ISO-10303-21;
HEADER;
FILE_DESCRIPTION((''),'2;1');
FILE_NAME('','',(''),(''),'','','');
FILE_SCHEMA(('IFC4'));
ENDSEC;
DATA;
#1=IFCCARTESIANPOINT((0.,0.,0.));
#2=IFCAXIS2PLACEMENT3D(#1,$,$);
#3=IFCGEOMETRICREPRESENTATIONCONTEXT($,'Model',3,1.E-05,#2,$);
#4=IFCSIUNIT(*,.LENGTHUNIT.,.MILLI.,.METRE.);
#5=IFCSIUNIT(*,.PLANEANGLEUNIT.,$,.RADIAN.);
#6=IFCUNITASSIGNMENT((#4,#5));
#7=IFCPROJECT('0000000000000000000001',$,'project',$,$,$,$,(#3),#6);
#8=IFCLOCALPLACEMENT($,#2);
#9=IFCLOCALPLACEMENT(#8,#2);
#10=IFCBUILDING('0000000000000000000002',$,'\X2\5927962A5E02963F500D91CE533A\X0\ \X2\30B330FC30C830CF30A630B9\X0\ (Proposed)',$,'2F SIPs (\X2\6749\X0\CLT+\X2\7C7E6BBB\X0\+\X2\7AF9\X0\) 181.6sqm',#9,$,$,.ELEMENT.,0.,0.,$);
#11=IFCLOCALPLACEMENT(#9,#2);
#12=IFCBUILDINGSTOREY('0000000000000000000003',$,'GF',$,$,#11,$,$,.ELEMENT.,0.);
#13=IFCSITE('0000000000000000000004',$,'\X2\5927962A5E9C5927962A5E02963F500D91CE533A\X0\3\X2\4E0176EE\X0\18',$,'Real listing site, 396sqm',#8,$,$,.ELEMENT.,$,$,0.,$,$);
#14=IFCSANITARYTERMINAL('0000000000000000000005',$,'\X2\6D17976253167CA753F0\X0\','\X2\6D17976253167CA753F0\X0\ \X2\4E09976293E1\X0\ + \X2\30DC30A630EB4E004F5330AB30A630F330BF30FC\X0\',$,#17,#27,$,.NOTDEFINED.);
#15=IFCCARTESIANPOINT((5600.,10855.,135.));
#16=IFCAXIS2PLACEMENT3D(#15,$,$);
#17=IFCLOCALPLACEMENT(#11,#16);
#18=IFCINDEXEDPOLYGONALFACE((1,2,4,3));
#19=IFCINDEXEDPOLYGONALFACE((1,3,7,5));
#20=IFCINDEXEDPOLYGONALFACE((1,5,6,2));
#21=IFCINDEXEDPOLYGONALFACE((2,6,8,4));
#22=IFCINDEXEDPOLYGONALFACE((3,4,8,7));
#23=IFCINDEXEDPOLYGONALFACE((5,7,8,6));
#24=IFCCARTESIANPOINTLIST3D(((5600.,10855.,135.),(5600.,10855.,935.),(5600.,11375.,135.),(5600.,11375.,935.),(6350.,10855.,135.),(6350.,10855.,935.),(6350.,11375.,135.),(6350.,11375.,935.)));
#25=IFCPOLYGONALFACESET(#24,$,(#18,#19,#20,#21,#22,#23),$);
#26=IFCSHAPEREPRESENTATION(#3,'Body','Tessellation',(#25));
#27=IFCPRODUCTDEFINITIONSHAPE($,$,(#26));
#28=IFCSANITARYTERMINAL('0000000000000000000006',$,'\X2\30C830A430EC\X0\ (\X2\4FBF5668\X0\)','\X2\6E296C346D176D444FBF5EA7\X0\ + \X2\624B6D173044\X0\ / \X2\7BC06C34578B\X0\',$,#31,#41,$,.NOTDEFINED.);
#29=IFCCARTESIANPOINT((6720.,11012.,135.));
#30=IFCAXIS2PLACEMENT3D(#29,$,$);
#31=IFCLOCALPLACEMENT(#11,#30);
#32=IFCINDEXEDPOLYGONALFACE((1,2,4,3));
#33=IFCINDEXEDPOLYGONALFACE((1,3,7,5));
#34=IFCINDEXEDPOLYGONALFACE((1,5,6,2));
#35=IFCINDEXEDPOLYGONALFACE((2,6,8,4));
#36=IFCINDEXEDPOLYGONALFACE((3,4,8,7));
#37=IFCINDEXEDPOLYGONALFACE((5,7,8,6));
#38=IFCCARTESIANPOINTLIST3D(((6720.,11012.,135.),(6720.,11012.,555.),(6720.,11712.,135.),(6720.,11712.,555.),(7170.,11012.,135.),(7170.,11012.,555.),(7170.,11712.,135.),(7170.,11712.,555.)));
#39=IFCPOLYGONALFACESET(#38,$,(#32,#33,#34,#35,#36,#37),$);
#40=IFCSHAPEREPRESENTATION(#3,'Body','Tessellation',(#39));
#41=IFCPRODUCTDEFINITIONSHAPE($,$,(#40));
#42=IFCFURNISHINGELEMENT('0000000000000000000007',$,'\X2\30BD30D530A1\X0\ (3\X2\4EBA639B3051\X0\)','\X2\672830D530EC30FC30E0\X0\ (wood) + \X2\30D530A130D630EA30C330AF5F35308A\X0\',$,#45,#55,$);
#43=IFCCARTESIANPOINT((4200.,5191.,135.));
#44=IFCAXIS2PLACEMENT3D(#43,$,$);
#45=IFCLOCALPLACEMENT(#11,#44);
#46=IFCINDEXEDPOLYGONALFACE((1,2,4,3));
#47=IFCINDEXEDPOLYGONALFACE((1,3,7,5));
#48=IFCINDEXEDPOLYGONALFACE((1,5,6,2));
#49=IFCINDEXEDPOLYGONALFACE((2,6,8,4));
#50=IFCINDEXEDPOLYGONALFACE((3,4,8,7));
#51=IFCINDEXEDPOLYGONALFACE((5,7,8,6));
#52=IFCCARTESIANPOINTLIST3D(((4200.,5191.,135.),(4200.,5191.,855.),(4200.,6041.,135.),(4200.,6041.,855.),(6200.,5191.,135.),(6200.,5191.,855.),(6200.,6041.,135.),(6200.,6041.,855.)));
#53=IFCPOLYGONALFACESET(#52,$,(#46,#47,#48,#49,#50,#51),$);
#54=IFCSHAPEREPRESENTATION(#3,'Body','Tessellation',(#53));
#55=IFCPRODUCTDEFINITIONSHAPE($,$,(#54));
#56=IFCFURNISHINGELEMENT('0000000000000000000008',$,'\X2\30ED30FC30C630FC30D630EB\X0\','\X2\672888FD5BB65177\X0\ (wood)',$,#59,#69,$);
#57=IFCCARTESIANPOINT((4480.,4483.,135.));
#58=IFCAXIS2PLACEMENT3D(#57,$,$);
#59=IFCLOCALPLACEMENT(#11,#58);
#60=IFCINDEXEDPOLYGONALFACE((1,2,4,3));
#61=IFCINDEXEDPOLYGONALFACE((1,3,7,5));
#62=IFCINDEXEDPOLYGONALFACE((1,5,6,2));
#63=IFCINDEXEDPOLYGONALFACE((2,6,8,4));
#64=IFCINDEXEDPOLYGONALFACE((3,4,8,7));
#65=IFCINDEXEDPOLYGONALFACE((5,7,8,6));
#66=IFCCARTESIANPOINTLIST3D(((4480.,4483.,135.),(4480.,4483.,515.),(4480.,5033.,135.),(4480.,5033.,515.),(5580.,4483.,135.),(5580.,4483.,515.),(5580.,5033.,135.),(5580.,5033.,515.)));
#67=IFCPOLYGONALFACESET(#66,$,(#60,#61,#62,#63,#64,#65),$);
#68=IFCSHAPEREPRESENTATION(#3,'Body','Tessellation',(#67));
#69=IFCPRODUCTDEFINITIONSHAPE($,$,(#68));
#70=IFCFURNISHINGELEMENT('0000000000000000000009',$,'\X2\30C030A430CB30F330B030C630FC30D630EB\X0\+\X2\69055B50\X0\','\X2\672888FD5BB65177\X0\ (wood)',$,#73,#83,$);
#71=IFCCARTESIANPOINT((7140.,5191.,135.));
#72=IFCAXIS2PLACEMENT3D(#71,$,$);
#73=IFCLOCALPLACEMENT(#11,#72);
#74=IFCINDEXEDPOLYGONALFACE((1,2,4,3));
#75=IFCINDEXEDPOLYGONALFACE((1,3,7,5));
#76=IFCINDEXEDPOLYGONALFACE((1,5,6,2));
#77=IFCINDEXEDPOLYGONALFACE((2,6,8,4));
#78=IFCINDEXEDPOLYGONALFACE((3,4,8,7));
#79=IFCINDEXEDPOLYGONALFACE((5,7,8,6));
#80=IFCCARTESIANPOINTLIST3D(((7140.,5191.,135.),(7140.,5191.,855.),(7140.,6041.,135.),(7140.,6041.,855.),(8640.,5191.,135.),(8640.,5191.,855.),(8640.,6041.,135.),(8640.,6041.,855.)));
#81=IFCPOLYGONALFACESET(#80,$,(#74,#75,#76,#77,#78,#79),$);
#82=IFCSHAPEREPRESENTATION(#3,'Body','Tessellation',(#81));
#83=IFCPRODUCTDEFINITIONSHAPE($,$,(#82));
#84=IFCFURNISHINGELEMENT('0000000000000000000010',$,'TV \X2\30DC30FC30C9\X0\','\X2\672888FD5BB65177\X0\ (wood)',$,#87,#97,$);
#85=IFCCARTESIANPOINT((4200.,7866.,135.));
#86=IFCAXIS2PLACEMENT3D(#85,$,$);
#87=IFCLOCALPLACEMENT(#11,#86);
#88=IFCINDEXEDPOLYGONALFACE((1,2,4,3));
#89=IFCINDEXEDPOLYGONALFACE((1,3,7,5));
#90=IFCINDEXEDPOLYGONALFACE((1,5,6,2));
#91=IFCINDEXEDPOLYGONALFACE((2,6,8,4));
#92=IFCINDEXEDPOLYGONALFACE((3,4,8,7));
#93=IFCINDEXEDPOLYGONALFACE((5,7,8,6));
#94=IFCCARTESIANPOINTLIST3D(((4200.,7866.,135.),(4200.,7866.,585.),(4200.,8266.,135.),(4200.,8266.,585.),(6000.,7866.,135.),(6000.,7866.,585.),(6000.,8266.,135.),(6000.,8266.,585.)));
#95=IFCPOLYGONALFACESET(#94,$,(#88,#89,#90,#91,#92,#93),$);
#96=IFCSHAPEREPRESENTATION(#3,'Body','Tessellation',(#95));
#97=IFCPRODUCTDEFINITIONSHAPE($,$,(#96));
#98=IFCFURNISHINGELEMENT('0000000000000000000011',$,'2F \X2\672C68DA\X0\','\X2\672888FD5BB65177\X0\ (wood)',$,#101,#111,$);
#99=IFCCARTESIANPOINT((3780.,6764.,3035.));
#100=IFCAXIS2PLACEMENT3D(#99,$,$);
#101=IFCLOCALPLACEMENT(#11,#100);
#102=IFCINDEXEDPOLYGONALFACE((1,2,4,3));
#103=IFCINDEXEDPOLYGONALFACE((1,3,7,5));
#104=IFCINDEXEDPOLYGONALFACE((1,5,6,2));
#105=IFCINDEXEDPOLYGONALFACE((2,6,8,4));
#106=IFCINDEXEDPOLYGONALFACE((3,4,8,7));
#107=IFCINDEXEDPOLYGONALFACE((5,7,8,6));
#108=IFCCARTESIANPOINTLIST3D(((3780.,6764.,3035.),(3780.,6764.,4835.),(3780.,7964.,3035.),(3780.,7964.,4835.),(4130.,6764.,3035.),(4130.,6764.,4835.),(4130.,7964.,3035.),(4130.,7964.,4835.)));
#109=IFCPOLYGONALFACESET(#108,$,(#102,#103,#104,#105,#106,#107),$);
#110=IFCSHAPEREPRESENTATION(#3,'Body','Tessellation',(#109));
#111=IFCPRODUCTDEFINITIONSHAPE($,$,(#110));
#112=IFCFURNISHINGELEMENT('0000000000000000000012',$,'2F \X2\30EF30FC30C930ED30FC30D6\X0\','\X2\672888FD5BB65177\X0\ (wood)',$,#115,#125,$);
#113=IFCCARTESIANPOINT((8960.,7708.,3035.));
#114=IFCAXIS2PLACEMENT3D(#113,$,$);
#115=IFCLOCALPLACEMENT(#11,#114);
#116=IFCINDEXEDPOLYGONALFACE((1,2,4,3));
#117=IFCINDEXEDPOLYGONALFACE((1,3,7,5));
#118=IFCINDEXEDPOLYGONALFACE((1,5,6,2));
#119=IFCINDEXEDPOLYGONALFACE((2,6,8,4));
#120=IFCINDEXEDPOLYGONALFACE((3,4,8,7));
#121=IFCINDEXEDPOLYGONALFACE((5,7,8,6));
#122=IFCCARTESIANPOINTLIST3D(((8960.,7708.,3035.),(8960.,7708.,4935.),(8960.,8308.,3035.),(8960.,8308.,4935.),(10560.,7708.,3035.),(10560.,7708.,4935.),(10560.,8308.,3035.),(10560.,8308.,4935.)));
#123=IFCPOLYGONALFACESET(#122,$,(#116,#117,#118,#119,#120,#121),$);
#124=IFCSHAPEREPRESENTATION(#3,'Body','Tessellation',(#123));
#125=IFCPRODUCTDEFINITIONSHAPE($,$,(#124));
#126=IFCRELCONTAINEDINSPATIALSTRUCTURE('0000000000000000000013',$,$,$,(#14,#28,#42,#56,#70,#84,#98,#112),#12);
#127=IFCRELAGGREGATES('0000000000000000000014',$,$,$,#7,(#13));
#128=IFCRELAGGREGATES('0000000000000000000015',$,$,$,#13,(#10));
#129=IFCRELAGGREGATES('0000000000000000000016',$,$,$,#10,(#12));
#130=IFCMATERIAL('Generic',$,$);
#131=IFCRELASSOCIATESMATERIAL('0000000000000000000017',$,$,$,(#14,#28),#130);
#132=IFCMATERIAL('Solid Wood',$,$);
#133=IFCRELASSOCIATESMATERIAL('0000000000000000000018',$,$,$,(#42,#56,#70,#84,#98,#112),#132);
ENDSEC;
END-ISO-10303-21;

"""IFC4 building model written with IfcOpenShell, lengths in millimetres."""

from ifc_helpers import new_model, si_unit, frame, frame_2d, origin, place, context, project, spatial, rectangle, extrude, material, element, save


model = new_model("IFC4")

# Units and contexts
model_context = context("Model", 3, precision=1e-05, world=origin())
ifc_project = project(units=[si_unit("LENGTHUNIT", "METRE", prefix="MILLI"), si_unit("PLANEANGLEUNIT", "RADIAN")], contexts=[model_context])

# Site, building, storey
site_placement = place(None, origin())
site = spatial("IfcSite", under=ifc_project, at=site_placement, Name="大阪府大阪市阿倍野区3丁目18", ObjectType="Real listing site, 396sqm", CompositionType="ELEMENT", RefElevation=0.0)
building_placement = place(site_placement, origin())
building = spatial("IfcBuilding", under=site, at=building_placement, Name="大阪市阿倍野区 コートハウス (Proposed)", ObjectType="2F SIPs (杉CLT+籾殻+竹) 181.6sqm", CompositionType="ELEMENT", ElevationOfRefHeight=0.0, ElevationOfTerrain=0.0)
storey_placement = place(building_placement, origin())
storey = spatial("IfcBuildingStorey", under=building, at=storey_placement, Name="GF", CompositionType="ELEMENT", Elevation=0.0)

# Shared definitions
ifc_material_1 = material(Name="Generic")

# Shared definitions
ifc_material_2 = material(Name="Solid Wood")

# Sanitary terminals
sanitary_terminal_1_placement = place(storey_placement, frame((5600.0, 10855.0, 135.0)))
element("IfcSanitaryTerminal", 1, at=sanitary_terminal_1_placement, inside=storey, material=ifc_material_1, Name="洗面化粧台", Description="洗面化粧台 三面鏡 + ボウル一体カウンター", PredefinedType="NOTDEFINED", context=model_context, shape_type="SweptSolid", body=[
    extrude(rectangle(XDim=750.0, YDim=520.0, at=frame_2d((375.0, 260.0))), frame((5600.0, 10855.0, 135.0)), (0.0, 0.0, 1.0), 800.0),
])
sanitary_terminal_2_placement = place(storey_placement, frame((6720.0, 11012.0, 135.0)))
element("IfcSanitaryTerminal", 2, at=sanitary_terminal_2_placement, inside=storey, material=ifc_material_1, Name="トイレ (便器)", Description="温水洗浄便座 + 手洗い / 節水型", PredefinedType="NOTDEFINED", context=model_context, shape_type="SweptSolid", body=[
    extrude(rectangle(XDim=450.0, YDim=700.0, at=frame_2d((225.0, 350.0))), frame((6720.0, 11012.0, 135.0)), (0.0, 0.0, 1.0), 420.0),
])

# Furnishing elements
furnishing_1_placement = place(storey_placement, frame((4200.0, 5191.0, 135.0)))
element("IfcFurnishingElement", 3, at=furnishing_1_placement, inside=storey, material=ifc_material_2, Name="ソファ (3人掛け)", Description="木フレーム (wood) + ファブリック張り", context=model_context, shape_type="SweptSolid", body=[
    extrude(rectangle(XDim=2000.0, YDim=850.0, at=frame_2d((1000.0, 425.0))), frame((4200.0, 5191.0, 135.0)), (0.0, 0.0, 1.0), 720.0),
])
furnishing_2_placement = place(storey_placement, frame((4480.0, 4483.0, 135.0)))
element("IfcFurnishingElement", 4, at=furnishing_2_placement, inside=storey, material=ifc_material_2, Name="ローテーブル", Description="木製家具 (wood)", context=model_context, shape_type="SweptSolid", body=[
    extrude(rectangle(XDim=1100.0, YDim=550.0, at=frame_2d((550.0, 275.0))), frame((4480.0, 4483.0, 135.0)), (0.0, 0.0, 1.0), 380.0),
])
furnishing_3_placement = place(storey_placement, frame((7140.0, 5191.0, 135.0)))
element("IfcFurnishingElement", 5, at=furnishing_3_placement, inside=storey, material=ifc_material_2, Name="ダイニングテーブル+椅子", Description="木製家具 (wood)", context=model_context, shape_type="SweptSolid", body=[
    extrude(rectangle(XDim=1500.0, YDim=850.0, at=frame_2d((750.0, 425.0))), frame((7140.0, 5191.0, 135.0)), (0.0, 0.0, 1.0), 720.0),
])
furnishing_4_placement = place(storey_placement, frame((4200.0, 7866.0, 135.0)))
element("IfcFurnishingElement", 6, at=furnishing_4_placement, inside=storey, material=ifc_material_2, Name="TV ボード", Description="木製家具 (wood)", context=model_context, shape_type="SweptSolid", body=[
    extrude(rectangle(XDim=1800.0, YDim=400.0, at=frame_2d((900.0, 200.0))), frame((4200.0, 7866.0, 135.0)), (0.0, 0.0, 1.0), 450.0),
])
furnishing_5_placement = place(storey_placement, frame((3780.0, 6764.0, 3035.0)))
element("IfcFurnishingElement", 7, at=furnishing_5_placement, inside=storey, material=ifc_material_2, Name="2F 本棚", Description="木製家具 (wood)", context=model_context, shape_type="SweptSolid", body=[
    extrude(rectangle(XDim=350.0, YDim=1200.0, at=frame_2d((175.0, 600.0))), frame((3780.0, 6764.0, 3035.0)), (0.0, 0.0, 1.0), 1800.0),
])
furnishing_6_placement = place(storey_placement, frame((8960.0, 7708.0, 3035.0)))
element("IfcFurnishingElement", 8, at=furnishing_6_placement, inside=storey, material=ifc_material_2, Name="2F ワードローブ", Description="木製家具 (wood)", context=model_context, shape_type="SweptSolid", body=[
    extrude(rectangle(XDim=1600.0, YDim=600.0, at=frame_2d((800.0, 300.0))), frame((8960.0, 7708.0, 3035.0)), (0.0, 0.0, 1.0), 1900.0),
])

save(model, "model.ifc")
